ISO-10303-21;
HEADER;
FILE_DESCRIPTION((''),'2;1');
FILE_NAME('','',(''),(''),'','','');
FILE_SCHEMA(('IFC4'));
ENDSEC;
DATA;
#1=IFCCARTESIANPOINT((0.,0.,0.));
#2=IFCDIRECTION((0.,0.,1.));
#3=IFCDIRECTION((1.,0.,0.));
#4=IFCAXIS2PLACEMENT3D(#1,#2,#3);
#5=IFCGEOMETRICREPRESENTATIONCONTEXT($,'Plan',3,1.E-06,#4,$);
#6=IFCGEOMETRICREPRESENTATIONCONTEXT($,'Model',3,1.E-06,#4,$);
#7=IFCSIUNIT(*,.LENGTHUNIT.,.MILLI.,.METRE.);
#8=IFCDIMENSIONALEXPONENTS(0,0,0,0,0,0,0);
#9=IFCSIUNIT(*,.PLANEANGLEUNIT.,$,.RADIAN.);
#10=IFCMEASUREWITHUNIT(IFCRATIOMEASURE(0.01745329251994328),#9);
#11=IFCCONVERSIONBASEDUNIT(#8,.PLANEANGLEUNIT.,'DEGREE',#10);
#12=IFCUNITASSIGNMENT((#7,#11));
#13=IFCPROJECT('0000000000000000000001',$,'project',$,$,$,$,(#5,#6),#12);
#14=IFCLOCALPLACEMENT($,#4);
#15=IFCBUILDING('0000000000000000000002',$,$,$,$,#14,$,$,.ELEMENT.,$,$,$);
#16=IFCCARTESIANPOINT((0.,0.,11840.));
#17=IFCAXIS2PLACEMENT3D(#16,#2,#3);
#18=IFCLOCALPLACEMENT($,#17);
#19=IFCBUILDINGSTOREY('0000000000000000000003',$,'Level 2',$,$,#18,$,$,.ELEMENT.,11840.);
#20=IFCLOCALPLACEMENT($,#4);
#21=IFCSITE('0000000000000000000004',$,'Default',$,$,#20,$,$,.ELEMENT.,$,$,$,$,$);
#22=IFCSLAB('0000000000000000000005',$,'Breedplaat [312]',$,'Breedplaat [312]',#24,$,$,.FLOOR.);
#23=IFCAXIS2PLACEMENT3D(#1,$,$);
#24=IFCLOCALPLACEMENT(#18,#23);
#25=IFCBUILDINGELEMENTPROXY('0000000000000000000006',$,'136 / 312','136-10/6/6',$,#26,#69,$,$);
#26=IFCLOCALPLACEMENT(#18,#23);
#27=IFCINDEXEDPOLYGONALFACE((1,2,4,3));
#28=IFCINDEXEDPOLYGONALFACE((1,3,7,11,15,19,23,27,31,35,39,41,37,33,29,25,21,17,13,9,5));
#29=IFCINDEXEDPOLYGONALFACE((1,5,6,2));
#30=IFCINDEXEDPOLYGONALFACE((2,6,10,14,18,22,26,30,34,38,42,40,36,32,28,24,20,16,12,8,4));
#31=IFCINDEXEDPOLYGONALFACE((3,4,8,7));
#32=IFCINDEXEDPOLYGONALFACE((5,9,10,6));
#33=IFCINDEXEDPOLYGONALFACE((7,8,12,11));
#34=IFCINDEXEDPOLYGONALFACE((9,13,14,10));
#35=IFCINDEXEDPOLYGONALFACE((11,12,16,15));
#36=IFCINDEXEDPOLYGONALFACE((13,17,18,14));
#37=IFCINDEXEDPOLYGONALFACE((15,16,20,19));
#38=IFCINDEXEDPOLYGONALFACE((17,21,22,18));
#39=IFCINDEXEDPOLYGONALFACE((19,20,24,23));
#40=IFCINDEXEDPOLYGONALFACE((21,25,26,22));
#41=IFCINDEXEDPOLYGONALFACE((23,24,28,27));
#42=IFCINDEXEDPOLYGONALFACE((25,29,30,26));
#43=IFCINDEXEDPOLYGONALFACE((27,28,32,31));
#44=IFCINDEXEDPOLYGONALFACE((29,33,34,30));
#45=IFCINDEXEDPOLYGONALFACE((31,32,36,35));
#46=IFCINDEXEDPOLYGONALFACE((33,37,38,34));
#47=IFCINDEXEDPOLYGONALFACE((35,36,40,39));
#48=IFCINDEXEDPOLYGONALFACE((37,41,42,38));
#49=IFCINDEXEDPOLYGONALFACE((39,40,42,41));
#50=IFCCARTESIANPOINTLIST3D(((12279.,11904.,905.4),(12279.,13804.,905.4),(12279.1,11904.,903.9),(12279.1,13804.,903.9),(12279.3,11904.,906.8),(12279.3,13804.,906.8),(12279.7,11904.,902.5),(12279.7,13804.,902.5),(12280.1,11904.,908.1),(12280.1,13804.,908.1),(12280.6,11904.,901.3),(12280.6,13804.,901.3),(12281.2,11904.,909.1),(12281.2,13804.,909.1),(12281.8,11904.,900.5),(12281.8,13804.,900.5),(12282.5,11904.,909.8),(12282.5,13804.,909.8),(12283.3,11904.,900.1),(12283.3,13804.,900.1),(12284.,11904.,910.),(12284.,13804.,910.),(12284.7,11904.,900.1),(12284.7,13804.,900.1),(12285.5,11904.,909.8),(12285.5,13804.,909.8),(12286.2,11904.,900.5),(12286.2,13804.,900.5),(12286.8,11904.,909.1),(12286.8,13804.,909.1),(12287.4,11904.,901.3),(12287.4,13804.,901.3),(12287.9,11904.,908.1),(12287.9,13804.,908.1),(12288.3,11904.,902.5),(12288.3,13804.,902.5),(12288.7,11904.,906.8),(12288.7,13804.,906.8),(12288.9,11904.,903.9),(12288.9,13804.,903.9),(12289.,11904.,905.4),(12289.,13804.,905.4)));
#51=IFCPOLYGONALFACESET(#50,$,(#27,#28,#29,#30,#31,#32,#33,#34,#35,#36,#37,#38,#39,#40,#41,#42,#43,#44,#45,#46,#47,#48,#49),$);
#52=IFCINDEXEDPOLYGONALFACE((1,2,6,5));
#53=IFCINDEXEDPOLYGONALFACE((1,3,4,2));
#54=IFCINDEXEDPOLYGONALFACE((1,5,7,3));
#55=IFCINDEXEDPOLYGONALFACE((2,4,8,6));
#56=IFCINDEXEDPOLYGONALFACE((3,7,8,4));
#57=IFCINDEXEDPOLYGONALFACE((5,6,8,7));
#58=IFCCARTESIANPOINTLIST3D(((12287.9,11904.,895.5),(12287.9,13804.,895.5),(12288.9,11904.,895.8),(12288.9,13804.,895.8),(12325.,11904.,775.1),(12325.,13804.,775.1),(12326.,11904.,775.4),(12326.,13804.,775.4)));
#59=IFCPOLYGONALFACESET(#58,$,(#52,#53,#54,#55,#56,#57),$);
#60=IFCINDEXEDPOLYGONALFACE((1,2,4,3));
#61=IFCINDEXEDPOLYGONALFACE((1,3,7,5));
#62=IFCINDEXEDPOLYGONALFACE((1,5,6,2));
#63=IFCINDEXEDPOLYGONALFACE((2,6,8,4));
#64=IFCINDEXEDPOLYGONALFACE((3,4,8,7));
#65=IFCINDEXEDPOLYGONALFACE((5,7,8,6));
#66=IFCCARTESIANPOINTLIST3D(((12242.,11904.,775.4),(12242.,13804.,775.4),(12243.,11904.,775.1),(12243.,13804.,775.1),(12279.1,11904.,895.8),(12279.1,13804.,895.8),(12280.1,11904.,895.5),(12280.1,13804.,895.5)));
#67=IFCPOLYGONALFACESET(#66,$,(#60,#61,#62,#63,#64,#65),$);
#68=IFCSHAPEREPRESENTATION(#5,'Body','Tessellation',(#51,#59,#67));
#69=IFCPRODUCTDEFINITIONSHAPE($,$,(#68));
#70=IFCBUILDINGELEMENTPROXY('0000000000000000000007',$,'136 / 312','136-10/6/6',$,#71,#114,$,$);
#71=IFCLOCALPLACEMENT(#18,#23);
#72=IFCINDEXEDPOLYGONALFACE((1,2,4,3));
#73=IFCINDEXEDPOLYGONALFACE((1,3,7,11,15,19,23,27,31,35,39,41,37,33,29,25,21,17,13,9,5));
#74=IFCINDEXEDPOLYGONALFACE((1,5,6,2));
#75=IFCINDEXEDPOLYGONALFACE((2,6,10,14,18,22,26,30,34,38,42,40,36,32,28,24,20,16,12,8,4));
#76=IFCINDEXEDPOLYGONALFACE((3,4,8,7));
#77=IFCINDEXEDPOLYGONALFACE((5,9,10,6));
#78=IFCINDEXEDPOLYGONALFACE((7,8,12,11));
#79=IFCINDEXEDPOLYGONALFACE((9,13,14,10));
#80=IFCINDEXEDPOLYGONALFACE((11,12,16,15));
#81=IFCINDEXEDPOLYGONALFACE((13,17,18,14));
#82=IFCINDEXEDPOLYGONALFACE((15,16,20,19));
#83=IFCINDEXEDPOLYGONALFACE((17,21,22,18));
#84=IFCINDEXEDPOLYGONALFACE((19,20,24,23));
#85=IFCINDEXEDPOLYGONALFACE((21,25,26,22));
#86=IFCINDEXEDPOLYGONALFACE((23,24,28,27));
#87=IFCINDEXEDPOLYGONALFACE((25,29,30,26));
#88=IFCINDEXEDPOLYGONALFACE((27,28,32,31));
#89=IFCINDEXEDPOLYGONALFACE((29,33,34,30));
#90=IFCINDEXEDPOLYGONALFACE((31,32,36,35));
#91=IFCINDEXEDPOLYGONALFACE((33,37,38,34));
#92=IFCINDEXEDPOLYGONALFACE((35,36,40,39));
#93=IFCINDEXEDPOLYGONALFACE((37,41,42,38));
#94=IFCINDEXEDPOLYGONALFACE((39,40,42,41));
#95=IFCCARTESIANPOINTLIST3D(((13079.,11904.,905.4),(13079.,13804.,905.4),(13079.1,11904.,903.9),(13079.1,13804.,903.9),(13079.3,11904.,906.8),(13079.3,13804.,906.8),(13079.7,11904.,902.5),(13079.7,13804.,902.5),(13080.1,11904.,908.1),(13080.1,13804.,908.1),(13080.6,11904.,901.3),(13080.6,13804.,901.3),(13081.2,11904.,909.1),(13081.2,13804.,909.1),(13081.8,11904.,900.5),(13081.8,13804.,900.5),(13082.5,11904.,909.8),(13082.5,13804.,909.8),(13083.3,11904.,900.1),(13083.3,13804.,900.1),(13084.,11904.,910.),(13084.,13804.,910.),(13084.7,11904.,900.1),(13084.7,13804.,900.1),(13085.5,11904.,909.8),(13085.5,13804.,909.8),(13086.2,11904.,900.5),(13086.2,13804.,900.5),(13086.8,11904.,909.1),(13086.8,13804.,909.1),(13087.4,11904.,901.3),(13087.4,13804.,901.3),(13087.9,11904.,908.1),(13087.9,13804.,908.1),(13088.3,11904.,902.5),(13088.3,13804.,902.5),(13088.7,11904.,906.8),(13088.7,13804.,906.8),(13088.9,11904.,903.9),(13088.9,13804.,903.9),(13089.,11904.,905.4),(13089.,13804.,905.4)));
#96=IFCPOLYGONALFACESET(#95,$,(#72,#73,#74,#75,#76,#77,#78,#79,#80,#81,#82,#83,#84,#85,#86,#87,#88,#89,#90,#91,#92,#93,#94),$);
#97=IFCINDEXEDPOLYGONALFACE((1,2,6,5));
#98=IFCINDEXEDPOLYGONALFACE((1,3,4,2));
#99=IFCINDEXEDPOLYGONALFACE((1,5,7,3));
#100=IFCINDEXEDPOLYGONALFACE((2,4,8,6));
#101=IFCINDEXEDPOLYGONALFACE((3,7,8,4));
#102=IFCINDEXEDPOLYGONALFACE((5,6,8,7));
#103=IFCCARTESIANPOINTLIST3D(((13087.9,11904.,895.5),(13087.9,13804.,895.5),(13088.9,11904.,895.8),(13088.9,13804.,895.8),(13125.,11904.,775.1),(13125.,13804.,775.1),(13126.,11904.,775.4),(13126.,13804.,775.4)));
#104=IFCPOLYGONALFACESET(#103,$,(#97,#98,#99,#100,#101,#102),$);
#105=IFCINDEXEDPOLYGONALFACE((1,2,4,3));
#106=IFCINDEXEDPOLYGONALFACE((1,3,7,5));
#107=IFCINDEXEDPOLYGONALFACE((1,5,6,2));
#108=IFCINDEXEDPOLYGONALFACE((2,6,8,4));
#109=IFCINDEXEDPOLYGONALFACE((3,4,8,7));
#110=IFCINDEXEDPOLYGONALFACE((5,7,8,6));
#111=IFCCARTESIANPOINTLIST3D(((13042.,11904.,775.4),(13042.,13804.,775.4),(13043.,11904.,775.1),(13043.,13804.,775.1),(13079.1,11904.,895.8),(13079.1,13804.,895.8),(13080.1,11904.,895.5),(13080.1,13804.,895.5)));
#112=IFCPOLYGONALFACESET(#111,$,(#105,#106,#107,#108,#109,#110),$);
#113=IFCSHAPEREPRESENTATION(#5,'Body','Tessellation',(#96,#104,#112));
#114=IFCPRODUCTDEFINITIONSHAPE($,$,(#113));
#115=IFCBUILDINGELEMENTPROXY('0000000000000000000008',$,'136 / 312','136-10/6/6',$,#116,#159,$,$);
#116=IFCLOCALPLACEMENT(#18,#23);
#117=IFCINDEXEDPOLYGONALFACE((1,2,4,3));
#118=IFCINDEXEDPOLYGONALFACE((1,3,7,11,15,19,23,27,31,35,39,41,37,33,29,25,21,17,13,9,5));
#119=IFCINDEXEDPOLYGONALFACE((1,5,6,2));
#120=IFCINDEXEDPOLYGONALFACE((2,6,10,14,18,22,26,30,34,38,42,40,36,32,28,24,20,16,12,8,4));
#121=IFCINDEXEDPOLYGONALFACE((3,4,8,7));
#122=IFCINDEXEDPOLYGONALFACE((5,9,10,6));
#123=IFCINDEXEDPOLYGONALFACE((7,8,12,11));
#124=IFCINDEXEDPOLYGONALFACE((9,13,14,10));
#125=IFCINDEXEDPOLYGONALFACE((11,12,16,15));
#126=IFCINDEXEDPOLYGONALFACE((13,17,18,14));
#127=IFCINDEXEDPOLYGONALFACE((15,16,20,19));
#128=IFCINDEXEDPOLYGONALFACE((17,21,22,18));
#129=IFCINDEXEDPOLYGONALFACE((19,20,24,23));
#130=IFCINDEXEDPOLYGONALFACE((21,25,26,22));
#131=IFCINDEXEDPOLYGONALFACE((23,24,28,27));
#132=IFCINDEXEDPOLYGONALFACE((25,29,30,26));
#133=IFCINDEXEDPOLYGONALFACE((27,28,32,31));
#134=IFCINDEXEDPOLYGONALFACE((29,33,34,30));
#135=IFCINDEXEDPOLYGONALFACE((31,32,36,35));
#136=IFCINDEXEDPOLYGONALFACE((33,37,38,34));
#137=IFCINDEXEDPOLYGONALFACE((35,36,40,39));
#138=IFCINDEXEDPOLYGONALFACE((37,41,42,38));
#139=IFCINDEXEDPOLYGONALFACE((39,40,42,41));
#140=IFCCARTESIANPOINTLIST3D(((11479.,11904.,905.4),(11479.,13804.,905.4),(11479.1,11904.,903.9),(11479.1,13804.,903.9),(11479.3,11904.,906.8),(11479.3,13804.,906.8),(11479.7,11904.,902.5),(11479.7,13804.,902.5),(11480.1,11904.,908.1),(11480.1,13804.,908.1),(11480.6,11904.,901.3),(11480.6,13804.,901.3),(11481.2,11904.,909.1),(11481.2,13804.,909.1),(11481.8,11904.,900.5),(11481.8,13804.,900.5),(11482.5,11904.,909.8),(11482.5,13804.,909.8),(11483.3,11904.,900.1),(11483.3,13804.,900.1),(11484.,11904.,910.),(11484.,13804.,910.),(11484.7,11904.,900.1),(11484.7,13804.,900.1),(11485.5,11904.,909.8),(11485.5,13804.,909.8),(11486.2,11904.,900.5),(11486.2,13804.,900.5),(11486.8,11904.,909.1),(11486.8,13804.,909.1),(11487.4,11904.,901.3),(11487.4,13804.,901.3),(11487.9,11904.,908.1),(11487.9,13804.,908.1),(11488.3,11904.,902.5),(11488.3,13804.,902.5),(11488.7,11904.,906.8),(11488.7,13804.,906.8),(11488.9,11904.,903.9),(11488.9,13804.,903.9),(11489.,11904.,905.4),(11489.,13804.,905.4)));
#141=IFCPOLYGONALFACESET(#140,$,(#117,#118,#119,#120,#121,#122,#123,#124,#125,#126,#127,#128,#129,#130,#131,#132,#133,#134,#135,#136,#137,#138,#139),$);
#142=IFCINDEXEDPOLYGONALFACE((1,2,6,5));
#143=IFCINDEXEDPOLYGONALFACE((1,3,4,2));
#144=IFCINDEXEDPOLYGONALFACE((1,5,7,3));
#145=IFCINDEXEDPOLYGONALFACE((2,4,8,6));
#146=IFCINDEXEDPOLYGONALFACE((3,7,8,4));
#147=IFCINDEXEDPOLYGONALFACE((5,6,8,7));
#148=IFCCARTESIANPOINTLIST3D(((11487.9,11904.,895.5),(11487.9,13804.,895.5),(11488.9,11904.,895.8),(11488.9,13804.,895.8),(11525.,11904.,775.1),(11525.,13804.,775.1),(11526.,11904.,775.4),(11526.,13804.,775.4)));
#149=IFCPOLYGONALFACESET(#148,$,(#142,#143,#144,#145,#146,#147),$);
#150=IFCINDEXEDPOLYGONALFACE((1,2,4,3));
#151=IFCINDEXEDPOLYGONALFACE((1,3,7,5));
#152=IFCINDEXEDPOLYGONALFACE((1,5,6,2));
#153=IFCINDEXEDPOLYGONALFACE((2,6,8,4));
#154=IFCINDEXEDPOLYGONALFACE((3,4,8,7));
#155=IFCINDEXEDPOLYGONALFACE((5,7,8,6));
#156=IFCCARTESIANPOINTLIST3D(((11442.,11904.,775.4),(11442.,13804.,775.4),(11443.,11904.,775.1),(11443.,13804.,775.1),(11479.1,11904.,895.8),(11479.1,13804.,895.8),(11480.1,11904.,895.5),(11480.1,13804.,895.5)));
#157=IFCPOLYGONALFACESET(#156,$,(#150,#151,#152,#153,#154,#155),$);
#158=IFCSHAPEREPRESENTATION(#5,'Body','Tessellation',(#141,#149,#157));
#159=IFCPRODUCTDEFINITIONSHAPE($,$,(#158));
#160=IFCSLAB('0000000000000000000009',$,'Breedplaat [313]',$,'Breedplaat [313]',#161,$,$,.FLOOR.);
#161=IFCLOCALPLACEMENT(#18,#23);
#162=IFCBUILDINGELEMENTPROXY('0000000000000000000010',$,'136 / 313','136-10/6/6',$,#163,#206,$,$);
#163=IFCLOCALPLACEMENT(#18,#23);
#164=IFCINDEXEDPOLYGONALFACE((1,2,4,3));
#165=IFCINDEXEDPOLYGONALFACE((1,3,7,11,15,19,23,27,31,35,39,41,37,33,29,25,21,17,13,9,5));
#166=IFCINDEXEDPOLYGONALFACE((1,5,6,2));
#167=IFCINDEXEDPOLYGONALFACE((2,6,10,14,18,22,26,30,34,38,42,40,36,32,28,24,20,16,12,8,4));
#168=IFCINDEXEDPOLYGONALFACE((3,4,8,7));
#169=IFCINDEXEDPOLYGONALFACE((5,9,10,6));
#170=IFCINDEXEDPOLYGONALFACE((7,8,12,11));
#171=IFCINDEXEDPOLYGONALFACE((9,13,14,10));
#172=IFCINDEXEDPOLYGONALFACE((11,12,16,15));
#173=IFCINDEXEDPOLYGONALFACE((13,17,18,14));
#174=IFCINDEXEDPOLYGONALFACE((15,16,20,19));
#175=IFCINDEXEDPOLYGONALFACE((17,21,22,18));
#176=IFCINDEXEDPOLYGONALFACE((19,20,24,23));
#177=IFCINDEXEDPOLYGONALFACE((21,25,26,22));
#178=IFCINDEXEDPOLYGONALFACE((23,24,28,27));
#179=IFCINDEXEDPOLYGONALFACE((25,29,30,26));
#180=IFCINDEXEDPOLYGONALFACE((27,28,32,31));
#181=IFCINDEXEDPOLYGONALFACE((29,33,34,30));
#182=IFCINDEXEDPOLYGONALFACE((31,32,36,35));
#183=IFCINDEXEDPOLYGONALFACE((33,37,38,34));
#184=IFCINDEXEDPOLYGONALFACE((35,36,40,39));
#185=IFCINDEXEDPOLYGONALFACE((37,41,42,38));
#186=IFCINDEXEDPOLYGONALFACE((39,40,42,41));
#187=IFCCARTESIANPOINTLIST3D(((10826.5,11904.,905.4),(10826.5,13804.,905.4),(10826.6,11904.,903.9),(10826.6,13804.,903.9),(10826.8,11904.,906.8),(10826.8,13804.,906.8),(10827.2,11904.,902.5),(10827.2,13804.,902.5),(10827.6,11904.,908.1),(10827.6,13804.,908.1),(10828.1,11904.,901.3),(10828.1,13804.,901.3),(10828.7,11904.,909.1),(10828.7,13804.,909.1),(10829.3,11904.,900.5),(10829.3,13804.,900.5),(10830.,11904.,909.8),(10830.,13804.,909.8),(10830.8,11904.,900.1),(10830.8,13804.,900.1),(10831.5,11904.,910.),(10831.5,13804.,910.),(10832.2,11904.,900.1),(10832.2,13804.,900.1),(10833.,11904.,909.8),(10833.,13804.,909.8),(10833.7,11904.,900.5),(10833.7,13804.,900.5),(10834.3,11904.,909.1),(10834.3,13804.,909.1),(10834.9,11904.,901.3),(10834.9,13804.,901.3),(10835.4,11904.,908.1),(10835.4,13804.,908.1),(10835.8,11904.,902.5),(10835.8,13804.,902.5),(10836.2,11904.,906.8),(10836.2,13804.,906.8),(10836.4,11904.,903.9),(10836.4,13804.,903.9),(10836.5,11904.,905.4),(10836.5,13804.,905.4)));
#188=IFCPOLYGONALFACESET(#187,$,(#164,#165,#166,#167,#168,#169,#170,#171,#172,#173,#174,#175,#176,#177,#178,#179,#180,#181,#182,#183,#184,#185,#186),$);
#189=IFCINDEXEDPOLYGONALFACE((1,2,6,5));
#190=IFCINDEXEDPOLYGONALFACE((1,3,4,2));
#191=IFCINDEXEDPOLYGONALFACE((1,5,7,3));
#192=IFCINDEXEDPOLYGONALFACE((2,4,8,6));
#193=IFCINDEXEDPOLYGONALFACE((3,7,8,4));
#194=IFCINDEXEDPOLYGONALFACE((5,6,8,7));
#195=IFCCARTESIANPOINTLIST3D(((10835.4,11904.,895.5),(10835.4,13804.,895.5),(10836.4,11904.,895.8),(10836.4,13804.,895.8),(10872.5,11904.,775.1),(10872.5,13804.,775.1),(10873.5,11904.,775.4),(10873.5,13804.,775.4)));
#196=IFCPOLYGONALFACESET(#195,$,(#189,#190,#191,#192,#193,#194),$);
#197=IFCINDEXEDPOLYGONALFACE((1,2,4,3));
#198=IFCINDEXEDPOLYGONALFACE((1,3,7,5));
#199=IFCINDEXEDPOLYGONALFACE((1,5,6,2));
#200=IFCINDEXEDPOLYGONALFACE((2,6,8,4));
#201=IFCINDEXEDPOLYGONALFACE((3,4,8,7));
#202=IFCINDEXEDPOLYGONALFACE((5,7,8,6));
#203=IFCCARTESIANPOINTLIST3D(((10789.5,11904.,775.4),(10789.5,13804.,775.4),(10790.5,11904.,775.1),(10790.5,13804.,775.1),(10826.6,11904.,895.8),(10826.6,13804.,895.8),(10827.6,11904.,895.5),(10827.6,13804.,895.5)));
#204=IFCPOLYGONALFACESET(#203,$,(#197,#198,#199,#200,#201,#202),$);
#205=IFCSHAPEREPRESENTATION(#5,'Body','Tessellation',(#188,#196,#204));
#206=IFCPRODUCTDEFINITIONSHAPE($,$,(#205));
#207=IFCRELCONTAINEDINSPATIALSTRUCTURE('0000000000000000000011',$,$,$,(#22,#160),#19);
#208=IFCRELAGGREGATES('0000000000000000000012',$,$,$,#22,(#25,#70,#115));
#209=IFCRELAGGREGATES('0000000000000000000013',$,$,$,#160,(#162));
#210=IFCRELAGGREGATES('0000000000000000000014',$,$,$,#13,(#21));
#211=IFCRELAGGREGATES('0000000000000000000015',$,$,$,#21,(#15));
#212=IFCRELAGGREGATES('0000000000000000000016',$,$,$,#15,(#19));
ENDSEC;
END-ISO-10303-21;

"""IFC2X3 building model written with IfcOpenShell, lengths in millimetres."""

from ifc_helpers import new_model, entity, si_unit, converted_unit, frame, origin_with_axes, origin_2d_with_axis, place, context, project, spatial, rectangle, circle, extrude, element, aggregate, save


model = new_model("IFC2X3")

# Units and contexts
plan_context = context("Plan", 3, precision=1e-06, world=origin_with_axes())
model_context = context("Model", 3, precision=1e-06, world=origin_with_axes())
ifc_project = project(units=[si_unit("LENGTHUNIT", "METRE", prefix="MILLI"), converted_unit("PLANEANGLEUNIT", "DEGREE", entity("IfcRatioMeasure", 0.01745329251994328), si_unit("PLANEANGLEUNIT", "RADIAN"), dimensions=[0, 0, 0, 0, 0, 0, 0])], contexts=[plan_context, model_context])

# Site, building, storey
site_placement = place(None, origin_with_axes())
site = spatial("IfcSite", under=ifc_project, at=site_placement, Name="Default", CompositionType="ELEMENT")
building_placement = place(None, origin_with_axes())
building = spatial("IfcBuilding", under=site, at=building_placement, CompositionType="ELEMENT")
storey_placement = place(None, frame((0.0, 0.0, 11840.0), z_axis=(0.0, 0.0, 1.0), x_axis=(1.0, 0.0, 0.0)))
storey = spatial("IfcBuildingStorey", under=building, at=storey_placement, Name="Level 2", CompositionType="ELEMENT", Elevation=11840.0)

# Slab, building element proxies
slab_1_placement = place(None, frame((13484.0, 11882.0, 12600.0), z_axis=(0.0, 0.0, 1.0), x_axis=(0.0, 1.0, 0.0)))
slab_1 = element("IfcSlab", 1, at=slab_1_placement, inside=storey, Name="Breedplaat [312]", ObjectType="Breedplaat [312]", PredefinedType="FLOOR")
proxy_1_placement = place(slab_1_placement, frame((22.0, 1200.0, 20.0), z_axis=(0.0, 0.0, 1.0), x_axis=(1.0, 0.0, 0.0)))
proxy_1 = element("IfcBuildingElementProxy", 2, at=proxy_1_placement, Name="136 / 312", Description="136-10/6/6", context=plan_context, shape_type="SweptSolid", body=[
    extrude(circle(Radius=5.0, at=origin_2d_with_axis()), frame((0.0, 0.0, 125.0), z_axis=(1.0, 0.0, 0.0), x_axis=(0.0, 0.0, 1.0)), (0.0, 0.0, 1.0), 1900.0),
    extrude(rectangle(XDim=126.0, YDim=1.0, at=origin_2d_with_axis()), frame((0.0, -22.9, 55.4), z_axis=(1.0, 0.0, 0.0), x_axis=(0.0, 0.294086, 0.955779)), (0.0, 0.0, 1.0), 1900.0),
    extrude(rectangle(XDim=126.0, YDim=1.0, at=origin_2d_with_axis()), frame((0.0, 22.9, 55.4), z_axis=(1.0, 0.0, 0.0), x_axis=(0.0, -0.294086, 0.955779)), (0.0, 0.0, 1.0), 1900.0),
])
proxy_2_placement = place(slab_1_placement, frame((22.0, 400.0, 20.0), z_axis=(0.0, 0.0, 1.0), x_axis=(1.0, 0.0, 0.0)))
proxy_2 = element("IfcBuildingElementProxy", 3, at=proxy_2_placement, Name="136 / 312", Description="136-10/6/6", context=plan_context, shape_type="SweptSolid", body=[
    extrude(circle(Radius=5.0, at=origin_2d_with_axis()), frame((0.0, 0.0, 125.0), z_axis=(1.0, 0.0, 0.0), x_axis=(0.0, 0.0, 1.0)), (0.0, 0.0, 1.0), 1900.0),
    extrude(rectangle(XDim=126.0, YDim=1.0, at=origin_2d_with_axis()), frame((0.0, -22.9, 55.4), z_axis=(1.0, 0.0, 0.0), x_axis=(0.0, 0.294086, 0.955779)), (0.0, 0.0, 1.0), 1900.0),
    extrude(rectangle(XDim=126.0, YDim=1.0, at=origin_2d_with_axis()), frame((0.0, 22.9, 55.4), z_axis=(1.0, 0.0, 0.0), x_axis=(0.0, -0.294086, 0.955779)), (0.0, 0.0, 1.0), 1900.0),
])
proxy_3_placement = place(slab_1_placement, frame((22.0, 2000.0, 20.0), z_axis=(0.0, 0.0, 1.0), x_axis=(1.0, 0.0, 0.0)))
proxy_3 = element("IfcBuildingElementProxy", 4, at=proxy_3_placement, Name="136 / 312", Description="136-10/6/6", context=plan_context, shape_type="SweptSolid", body=[
    extrude(circle(Radius=5.0, at=origin_2d_with_axis()), frame((0.0, 0.0, 125.0), z_axis=(1.0, 0.0, 0.0), x_axis=(0.0, 0.0, 1.0)), (0.0, 0.0, 1.0), 1900.0),
    extrude(rectangle(XDim=126.0, YDim=1.0, at=origin_2d_with_axis()), frame((0.0, -22.9, 55.4), z_axis=(1.0, 0.0, 0.0), x_axis=(0.0, 0.294086, 0.955779)), (0.0, 0.0, 1.0), 1900.0),
    extrude(rectangle(XDim=126.0, YDim=1.0, at=origin_2d_with_axis()), frame((0.0, 22.9, 55.4), z_axis=(1.0, 0.0, 0.0), x_axis=(0.0, -0.294086, 0.955779)), (0.0, 0.0, 1.0), 1900.0),
])
aggregate(slab_1, [proxy_1, proxy_2, proxy_3])

# Slab, building element proxy
slab_2_placement = place(None, frame((11087.0, 11882.0, 12600.0), z_axis=(0.0, 0.0, 1.0), x_axis=(0.0, 1.0, 0.0)))
slab_2 = element("IfcSlab", 5, at=slab_2_placement, inside=storey, Name="Breedplaat [313]", ObjectType="Breedplaat [313]", PredefinedType="FLOOR")
proxy_4_placement = place(slab_2_placement, frame((22.0, 255.5, 20.0), z_axis=(0.0, 0.0, 1.0), x_axis=(1.0, 0.0, 0.0)))
proxy_4 = element("IfcBuildingElementProxy", 6, at=proxy_4_placement, Name="136 / 313", Description="136-10/6/6", context=plan_context, shape_type="SweptSolid", body=[
    extrude(circle(Radius=5.0, at=origin_2d_with_axis()), frame((0.0, 0.0, 125.0), z_axis=(1.0, 0.0, 0.0), x_axis=(0.0, 0.0, 1.0)), (0.0, 0.0, 1.0), 1900.0),
    extrude(rectangle(XDim=126.0, YDim=1.0, at=origin_2d_with_axis()), frame((0.0, -22.9, 55.4), z_axis=(1.0, 0.0, 0.0), x_axis=(0.0, 0.294086, 0.955779)), (0.0, 0.0, 1.0), 1900.0),
    extrude(rectangle(XDim=126.0, YDim=1.0, at=origin_2d_with_axis()), frame((0.0, 22.9, 55.4), z_axis=(1.0, 0.0, 0.0), x_axis=(0.0, -0.294086, 0.955779)), (0.0, 0.0, 1.0), 1900.0),
])
aggregate(slab_2, [proxy_4])

save(model, "model.ifc")
